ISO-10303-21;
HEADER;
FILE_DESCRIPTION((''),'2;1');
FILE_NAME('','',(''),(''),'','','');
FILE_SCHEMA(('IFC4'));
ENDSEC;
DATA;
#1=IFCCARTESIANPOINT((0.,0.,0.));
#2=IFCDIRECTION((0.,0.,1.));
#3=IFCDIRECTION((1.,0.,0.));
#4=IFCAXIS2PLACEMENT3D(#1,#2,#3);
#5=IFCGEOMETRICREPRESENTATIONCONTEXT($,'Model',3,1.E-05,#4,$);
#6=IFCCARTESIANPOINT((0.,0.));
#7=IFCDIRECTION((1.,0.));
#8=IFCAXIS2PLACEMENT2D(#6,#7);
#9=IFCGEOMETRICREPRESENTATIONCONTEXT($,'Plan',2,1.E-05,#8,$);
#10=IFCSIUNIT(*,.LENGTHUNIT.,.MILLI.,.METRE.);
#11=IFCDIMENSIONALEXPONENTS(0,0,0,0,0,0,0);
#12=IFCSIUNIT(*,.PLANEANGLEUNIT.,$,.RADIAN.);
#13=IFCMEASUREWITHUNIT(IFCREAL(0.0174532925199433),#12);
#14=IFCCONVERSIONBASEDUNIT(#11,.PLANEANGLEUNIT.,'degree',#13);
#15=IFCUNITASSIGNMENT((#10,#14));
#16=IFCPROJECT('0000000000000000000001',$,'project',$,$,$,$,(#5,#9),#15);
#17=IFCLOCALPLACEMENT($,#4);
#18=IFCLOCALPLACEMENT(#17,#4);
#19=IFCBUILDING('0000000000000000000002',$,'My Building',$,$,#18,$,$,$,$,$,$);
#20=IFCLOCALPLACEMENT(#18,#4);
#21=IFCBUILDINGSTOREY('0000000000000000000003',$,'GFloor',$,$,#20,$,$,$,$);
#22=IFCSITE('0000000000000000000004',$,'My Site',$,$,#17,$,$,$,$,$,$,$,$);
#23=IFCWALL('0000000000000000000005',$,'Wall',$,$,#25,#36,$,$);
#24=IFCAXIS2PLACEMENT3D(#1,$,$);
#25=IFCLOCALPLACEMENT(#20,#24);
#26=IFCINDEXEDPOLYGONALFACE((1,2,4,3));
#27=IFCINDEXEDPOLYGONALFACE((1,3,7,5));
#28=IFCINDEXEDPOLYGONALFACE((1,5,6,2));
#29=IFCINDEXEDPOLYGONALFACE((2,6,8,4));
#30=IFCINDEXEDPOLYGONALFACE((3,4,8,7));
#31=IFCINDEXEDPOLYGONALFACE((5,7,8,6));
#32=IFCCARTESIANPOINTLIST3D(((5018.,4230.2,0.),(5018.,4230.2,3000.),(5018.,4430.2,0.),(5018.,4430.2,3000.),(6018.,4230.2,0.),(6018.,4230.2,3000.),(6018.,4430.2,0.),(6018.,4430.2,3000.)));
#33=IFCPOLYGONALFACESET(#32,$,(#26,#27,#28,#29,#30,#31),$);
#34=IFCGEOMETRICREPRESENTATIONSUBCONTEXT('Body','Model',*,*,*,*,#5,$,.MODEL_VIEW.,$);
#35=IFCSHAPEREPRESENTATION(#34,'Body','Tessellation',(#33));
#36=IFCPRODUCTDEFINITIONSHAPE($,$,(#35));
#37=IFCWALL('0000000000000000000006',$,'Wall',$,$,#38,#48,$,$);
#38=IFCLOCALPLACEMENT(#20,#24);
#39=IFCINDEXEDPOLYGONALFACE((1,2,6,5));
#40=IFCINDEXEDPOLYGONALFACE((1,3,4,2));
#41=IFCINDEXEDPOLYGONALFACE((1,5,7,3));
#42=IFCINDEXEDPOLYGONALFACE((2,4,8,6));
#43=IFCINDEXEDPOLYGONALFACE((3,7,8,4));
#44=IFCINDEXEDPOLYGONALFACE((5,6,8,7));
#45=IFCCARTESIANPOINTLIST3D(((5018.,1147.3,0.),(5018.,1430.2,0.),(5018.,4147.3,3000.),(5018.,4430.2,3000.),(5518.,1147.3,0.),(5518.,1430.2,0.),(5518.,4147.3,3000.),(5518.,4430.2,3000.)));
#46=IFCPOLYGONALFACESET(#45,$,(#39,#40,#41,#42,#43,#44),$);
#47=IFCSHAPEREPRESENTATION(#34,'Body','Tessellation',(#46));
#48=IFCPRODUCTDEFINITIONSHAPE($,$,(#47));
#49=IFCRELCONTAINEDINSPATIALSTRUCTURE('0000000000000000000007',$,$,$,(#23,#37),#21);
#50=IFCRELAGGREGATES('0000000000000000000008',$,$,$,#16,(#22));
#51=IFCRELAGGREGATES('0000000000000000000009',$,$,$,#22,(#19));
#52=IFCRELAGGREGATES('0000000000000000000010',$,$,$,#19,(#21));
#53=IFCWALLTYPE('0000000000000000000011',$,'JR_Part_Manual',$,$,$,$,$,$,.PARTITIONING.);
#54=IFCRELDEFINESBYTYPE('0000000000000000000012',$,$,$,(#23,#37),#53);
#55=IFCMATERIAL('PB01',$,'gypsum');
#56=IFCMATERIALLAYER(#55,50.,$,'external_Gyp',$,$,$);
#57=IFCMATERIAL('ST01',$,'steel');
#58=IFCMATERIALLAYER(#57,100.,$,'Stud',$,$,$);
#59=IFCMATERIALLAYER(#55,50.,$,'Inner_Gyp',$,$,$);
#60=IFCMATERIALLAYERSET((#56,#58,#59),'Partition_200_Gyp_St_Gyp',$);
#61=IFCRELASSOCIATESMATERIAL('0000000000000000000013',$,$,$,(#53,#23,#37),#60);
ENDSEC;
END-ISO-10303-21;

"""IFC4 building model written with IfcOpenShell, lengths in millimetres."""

from ifc_helpers import new_model, entity, si_unit, converted_unit, frame, origin_with_axes, origin_2d_with_axis, place, context, subcontext, project, spatial, indexed_curve, outline, extrude, material, layer, layer_set, layer_usage, type_object, element, save


model = new_model("IFC4")

# Units and contexts
model_context = context("Model", 3, precision=1e-05, world=origin_with_axes())
plan_context = context("Plan", 2, precision=1e-05, world=origin_2d_with_axis())
body_context_1 = subcontext(model_context, "Body", "Model", "MODEL_VIEW")
ifc_project = project(units=[si_unit("LENGTHUNIT", "METRE", prefix="MILLI"), converted_unit("PLANEANGLEUNIT", "degree", entity("IfcReal", 0.0174532925199433), si_unit("PLANEANGLEUNIT", "RADIAN"), dimensions=[0, 0, 0, 0, 0, 0, 0])], contexts=[model_context, plan_context])

# Site, building, storey
site_placement = place(None, origin_with_axes())
site = spatial("IfcSite", under=ifc_project, at=site_placement, Name="My Site")
building_placement = place(site_placement, origin_with_axes())
building = spatial("IfcBuilding", under=site, at=building_placement, Name="My Building")
storey_placement = place(building_placement, origin_with_axes())
storey = spatial("IfcBuildingStorey", under=building, at=storey_placement, Name="GFloor")

# Walls
ifc_material_1 = material(Name="PB01", Category="gypsum")
ifc_layer_1 = layer(ifc_material_1, 50.0, Name="external_Gyp")
ifc_material_2 = material(Name="ST01", Category="steel")
ifc_layer_2 = layer(ifc_material_2, 100.0, Name="Stud")
ifc_layer_3 = layer(ifc_material_1, 50.0, Name="Inner_Gyp")
ifc_layer_set_1 = layer_set([ifc_layer_1, ifc_layer_2, ifc_layer_3], Name="Partition_200_Gyp_St_Gyp")
ifc_layer_usage_1 = layer_usage(ifc_layer_set_1, "AXIS2", "POSITIVE", 0.0)
wall_type_1 = type_object("IfcWallType", Name="JR_Part_Manual", PredefinedType="PARTITIONING", material=ifc_layer_set_1)
wall_1_placement = place(storey_placement, frame((5018.0, 4230.2, 0.0), z_axis=(0.0, 0.0, 1.0), x_axis=(1.0, 0.0, 0.0)))
element("IfcWall", 1, at=wall_1_placement, inside=storey, type_object=wall_type_1, material=ifc_layer_usage_1, Name="Wall", context=body_context_1, shape_type="SweptSolid", body=[
    extrude(outline(indexed_curve([(0.0, 0.0), (0.0, 200.0), (1000.0, 200.0), (1000.0, 0.0), (0.0, 0.0)], self_intersect=False)), origin_with_axes(), (0.0, 0.0, 1.0), 3000.0),
])
ifc_layer_usage_2 = layer_usage(ifc_layer_set_1, "AXIS2", "POSITIVE", 0.0)
wall_2_placement = place(storey_placement, frame((5018.0, 1147.3, 0.0), z_axis=(0.0, 0.0, 1.0), x_axis=(1.0, 0.0, 0.0)))
element("IfcWall", 2, at=wall_2_placement, inside=storey, type_object=wall_type_1, material=ifc_layer_usage_2, Name="Wall", context=body_context_1, shape_type="SweptSolid", body=[
    extrude(outline(indexed_curve([(0.0, 0.0), (0.0, 282.8), (500.0, 282.8), (500.0, 0.0), (0.0, 0.0)], self_intersect=False)), origin_with_axes(), (0.0, 0.707107, 0.707107), 4242.6),
])

save(model, "model.ifc")
